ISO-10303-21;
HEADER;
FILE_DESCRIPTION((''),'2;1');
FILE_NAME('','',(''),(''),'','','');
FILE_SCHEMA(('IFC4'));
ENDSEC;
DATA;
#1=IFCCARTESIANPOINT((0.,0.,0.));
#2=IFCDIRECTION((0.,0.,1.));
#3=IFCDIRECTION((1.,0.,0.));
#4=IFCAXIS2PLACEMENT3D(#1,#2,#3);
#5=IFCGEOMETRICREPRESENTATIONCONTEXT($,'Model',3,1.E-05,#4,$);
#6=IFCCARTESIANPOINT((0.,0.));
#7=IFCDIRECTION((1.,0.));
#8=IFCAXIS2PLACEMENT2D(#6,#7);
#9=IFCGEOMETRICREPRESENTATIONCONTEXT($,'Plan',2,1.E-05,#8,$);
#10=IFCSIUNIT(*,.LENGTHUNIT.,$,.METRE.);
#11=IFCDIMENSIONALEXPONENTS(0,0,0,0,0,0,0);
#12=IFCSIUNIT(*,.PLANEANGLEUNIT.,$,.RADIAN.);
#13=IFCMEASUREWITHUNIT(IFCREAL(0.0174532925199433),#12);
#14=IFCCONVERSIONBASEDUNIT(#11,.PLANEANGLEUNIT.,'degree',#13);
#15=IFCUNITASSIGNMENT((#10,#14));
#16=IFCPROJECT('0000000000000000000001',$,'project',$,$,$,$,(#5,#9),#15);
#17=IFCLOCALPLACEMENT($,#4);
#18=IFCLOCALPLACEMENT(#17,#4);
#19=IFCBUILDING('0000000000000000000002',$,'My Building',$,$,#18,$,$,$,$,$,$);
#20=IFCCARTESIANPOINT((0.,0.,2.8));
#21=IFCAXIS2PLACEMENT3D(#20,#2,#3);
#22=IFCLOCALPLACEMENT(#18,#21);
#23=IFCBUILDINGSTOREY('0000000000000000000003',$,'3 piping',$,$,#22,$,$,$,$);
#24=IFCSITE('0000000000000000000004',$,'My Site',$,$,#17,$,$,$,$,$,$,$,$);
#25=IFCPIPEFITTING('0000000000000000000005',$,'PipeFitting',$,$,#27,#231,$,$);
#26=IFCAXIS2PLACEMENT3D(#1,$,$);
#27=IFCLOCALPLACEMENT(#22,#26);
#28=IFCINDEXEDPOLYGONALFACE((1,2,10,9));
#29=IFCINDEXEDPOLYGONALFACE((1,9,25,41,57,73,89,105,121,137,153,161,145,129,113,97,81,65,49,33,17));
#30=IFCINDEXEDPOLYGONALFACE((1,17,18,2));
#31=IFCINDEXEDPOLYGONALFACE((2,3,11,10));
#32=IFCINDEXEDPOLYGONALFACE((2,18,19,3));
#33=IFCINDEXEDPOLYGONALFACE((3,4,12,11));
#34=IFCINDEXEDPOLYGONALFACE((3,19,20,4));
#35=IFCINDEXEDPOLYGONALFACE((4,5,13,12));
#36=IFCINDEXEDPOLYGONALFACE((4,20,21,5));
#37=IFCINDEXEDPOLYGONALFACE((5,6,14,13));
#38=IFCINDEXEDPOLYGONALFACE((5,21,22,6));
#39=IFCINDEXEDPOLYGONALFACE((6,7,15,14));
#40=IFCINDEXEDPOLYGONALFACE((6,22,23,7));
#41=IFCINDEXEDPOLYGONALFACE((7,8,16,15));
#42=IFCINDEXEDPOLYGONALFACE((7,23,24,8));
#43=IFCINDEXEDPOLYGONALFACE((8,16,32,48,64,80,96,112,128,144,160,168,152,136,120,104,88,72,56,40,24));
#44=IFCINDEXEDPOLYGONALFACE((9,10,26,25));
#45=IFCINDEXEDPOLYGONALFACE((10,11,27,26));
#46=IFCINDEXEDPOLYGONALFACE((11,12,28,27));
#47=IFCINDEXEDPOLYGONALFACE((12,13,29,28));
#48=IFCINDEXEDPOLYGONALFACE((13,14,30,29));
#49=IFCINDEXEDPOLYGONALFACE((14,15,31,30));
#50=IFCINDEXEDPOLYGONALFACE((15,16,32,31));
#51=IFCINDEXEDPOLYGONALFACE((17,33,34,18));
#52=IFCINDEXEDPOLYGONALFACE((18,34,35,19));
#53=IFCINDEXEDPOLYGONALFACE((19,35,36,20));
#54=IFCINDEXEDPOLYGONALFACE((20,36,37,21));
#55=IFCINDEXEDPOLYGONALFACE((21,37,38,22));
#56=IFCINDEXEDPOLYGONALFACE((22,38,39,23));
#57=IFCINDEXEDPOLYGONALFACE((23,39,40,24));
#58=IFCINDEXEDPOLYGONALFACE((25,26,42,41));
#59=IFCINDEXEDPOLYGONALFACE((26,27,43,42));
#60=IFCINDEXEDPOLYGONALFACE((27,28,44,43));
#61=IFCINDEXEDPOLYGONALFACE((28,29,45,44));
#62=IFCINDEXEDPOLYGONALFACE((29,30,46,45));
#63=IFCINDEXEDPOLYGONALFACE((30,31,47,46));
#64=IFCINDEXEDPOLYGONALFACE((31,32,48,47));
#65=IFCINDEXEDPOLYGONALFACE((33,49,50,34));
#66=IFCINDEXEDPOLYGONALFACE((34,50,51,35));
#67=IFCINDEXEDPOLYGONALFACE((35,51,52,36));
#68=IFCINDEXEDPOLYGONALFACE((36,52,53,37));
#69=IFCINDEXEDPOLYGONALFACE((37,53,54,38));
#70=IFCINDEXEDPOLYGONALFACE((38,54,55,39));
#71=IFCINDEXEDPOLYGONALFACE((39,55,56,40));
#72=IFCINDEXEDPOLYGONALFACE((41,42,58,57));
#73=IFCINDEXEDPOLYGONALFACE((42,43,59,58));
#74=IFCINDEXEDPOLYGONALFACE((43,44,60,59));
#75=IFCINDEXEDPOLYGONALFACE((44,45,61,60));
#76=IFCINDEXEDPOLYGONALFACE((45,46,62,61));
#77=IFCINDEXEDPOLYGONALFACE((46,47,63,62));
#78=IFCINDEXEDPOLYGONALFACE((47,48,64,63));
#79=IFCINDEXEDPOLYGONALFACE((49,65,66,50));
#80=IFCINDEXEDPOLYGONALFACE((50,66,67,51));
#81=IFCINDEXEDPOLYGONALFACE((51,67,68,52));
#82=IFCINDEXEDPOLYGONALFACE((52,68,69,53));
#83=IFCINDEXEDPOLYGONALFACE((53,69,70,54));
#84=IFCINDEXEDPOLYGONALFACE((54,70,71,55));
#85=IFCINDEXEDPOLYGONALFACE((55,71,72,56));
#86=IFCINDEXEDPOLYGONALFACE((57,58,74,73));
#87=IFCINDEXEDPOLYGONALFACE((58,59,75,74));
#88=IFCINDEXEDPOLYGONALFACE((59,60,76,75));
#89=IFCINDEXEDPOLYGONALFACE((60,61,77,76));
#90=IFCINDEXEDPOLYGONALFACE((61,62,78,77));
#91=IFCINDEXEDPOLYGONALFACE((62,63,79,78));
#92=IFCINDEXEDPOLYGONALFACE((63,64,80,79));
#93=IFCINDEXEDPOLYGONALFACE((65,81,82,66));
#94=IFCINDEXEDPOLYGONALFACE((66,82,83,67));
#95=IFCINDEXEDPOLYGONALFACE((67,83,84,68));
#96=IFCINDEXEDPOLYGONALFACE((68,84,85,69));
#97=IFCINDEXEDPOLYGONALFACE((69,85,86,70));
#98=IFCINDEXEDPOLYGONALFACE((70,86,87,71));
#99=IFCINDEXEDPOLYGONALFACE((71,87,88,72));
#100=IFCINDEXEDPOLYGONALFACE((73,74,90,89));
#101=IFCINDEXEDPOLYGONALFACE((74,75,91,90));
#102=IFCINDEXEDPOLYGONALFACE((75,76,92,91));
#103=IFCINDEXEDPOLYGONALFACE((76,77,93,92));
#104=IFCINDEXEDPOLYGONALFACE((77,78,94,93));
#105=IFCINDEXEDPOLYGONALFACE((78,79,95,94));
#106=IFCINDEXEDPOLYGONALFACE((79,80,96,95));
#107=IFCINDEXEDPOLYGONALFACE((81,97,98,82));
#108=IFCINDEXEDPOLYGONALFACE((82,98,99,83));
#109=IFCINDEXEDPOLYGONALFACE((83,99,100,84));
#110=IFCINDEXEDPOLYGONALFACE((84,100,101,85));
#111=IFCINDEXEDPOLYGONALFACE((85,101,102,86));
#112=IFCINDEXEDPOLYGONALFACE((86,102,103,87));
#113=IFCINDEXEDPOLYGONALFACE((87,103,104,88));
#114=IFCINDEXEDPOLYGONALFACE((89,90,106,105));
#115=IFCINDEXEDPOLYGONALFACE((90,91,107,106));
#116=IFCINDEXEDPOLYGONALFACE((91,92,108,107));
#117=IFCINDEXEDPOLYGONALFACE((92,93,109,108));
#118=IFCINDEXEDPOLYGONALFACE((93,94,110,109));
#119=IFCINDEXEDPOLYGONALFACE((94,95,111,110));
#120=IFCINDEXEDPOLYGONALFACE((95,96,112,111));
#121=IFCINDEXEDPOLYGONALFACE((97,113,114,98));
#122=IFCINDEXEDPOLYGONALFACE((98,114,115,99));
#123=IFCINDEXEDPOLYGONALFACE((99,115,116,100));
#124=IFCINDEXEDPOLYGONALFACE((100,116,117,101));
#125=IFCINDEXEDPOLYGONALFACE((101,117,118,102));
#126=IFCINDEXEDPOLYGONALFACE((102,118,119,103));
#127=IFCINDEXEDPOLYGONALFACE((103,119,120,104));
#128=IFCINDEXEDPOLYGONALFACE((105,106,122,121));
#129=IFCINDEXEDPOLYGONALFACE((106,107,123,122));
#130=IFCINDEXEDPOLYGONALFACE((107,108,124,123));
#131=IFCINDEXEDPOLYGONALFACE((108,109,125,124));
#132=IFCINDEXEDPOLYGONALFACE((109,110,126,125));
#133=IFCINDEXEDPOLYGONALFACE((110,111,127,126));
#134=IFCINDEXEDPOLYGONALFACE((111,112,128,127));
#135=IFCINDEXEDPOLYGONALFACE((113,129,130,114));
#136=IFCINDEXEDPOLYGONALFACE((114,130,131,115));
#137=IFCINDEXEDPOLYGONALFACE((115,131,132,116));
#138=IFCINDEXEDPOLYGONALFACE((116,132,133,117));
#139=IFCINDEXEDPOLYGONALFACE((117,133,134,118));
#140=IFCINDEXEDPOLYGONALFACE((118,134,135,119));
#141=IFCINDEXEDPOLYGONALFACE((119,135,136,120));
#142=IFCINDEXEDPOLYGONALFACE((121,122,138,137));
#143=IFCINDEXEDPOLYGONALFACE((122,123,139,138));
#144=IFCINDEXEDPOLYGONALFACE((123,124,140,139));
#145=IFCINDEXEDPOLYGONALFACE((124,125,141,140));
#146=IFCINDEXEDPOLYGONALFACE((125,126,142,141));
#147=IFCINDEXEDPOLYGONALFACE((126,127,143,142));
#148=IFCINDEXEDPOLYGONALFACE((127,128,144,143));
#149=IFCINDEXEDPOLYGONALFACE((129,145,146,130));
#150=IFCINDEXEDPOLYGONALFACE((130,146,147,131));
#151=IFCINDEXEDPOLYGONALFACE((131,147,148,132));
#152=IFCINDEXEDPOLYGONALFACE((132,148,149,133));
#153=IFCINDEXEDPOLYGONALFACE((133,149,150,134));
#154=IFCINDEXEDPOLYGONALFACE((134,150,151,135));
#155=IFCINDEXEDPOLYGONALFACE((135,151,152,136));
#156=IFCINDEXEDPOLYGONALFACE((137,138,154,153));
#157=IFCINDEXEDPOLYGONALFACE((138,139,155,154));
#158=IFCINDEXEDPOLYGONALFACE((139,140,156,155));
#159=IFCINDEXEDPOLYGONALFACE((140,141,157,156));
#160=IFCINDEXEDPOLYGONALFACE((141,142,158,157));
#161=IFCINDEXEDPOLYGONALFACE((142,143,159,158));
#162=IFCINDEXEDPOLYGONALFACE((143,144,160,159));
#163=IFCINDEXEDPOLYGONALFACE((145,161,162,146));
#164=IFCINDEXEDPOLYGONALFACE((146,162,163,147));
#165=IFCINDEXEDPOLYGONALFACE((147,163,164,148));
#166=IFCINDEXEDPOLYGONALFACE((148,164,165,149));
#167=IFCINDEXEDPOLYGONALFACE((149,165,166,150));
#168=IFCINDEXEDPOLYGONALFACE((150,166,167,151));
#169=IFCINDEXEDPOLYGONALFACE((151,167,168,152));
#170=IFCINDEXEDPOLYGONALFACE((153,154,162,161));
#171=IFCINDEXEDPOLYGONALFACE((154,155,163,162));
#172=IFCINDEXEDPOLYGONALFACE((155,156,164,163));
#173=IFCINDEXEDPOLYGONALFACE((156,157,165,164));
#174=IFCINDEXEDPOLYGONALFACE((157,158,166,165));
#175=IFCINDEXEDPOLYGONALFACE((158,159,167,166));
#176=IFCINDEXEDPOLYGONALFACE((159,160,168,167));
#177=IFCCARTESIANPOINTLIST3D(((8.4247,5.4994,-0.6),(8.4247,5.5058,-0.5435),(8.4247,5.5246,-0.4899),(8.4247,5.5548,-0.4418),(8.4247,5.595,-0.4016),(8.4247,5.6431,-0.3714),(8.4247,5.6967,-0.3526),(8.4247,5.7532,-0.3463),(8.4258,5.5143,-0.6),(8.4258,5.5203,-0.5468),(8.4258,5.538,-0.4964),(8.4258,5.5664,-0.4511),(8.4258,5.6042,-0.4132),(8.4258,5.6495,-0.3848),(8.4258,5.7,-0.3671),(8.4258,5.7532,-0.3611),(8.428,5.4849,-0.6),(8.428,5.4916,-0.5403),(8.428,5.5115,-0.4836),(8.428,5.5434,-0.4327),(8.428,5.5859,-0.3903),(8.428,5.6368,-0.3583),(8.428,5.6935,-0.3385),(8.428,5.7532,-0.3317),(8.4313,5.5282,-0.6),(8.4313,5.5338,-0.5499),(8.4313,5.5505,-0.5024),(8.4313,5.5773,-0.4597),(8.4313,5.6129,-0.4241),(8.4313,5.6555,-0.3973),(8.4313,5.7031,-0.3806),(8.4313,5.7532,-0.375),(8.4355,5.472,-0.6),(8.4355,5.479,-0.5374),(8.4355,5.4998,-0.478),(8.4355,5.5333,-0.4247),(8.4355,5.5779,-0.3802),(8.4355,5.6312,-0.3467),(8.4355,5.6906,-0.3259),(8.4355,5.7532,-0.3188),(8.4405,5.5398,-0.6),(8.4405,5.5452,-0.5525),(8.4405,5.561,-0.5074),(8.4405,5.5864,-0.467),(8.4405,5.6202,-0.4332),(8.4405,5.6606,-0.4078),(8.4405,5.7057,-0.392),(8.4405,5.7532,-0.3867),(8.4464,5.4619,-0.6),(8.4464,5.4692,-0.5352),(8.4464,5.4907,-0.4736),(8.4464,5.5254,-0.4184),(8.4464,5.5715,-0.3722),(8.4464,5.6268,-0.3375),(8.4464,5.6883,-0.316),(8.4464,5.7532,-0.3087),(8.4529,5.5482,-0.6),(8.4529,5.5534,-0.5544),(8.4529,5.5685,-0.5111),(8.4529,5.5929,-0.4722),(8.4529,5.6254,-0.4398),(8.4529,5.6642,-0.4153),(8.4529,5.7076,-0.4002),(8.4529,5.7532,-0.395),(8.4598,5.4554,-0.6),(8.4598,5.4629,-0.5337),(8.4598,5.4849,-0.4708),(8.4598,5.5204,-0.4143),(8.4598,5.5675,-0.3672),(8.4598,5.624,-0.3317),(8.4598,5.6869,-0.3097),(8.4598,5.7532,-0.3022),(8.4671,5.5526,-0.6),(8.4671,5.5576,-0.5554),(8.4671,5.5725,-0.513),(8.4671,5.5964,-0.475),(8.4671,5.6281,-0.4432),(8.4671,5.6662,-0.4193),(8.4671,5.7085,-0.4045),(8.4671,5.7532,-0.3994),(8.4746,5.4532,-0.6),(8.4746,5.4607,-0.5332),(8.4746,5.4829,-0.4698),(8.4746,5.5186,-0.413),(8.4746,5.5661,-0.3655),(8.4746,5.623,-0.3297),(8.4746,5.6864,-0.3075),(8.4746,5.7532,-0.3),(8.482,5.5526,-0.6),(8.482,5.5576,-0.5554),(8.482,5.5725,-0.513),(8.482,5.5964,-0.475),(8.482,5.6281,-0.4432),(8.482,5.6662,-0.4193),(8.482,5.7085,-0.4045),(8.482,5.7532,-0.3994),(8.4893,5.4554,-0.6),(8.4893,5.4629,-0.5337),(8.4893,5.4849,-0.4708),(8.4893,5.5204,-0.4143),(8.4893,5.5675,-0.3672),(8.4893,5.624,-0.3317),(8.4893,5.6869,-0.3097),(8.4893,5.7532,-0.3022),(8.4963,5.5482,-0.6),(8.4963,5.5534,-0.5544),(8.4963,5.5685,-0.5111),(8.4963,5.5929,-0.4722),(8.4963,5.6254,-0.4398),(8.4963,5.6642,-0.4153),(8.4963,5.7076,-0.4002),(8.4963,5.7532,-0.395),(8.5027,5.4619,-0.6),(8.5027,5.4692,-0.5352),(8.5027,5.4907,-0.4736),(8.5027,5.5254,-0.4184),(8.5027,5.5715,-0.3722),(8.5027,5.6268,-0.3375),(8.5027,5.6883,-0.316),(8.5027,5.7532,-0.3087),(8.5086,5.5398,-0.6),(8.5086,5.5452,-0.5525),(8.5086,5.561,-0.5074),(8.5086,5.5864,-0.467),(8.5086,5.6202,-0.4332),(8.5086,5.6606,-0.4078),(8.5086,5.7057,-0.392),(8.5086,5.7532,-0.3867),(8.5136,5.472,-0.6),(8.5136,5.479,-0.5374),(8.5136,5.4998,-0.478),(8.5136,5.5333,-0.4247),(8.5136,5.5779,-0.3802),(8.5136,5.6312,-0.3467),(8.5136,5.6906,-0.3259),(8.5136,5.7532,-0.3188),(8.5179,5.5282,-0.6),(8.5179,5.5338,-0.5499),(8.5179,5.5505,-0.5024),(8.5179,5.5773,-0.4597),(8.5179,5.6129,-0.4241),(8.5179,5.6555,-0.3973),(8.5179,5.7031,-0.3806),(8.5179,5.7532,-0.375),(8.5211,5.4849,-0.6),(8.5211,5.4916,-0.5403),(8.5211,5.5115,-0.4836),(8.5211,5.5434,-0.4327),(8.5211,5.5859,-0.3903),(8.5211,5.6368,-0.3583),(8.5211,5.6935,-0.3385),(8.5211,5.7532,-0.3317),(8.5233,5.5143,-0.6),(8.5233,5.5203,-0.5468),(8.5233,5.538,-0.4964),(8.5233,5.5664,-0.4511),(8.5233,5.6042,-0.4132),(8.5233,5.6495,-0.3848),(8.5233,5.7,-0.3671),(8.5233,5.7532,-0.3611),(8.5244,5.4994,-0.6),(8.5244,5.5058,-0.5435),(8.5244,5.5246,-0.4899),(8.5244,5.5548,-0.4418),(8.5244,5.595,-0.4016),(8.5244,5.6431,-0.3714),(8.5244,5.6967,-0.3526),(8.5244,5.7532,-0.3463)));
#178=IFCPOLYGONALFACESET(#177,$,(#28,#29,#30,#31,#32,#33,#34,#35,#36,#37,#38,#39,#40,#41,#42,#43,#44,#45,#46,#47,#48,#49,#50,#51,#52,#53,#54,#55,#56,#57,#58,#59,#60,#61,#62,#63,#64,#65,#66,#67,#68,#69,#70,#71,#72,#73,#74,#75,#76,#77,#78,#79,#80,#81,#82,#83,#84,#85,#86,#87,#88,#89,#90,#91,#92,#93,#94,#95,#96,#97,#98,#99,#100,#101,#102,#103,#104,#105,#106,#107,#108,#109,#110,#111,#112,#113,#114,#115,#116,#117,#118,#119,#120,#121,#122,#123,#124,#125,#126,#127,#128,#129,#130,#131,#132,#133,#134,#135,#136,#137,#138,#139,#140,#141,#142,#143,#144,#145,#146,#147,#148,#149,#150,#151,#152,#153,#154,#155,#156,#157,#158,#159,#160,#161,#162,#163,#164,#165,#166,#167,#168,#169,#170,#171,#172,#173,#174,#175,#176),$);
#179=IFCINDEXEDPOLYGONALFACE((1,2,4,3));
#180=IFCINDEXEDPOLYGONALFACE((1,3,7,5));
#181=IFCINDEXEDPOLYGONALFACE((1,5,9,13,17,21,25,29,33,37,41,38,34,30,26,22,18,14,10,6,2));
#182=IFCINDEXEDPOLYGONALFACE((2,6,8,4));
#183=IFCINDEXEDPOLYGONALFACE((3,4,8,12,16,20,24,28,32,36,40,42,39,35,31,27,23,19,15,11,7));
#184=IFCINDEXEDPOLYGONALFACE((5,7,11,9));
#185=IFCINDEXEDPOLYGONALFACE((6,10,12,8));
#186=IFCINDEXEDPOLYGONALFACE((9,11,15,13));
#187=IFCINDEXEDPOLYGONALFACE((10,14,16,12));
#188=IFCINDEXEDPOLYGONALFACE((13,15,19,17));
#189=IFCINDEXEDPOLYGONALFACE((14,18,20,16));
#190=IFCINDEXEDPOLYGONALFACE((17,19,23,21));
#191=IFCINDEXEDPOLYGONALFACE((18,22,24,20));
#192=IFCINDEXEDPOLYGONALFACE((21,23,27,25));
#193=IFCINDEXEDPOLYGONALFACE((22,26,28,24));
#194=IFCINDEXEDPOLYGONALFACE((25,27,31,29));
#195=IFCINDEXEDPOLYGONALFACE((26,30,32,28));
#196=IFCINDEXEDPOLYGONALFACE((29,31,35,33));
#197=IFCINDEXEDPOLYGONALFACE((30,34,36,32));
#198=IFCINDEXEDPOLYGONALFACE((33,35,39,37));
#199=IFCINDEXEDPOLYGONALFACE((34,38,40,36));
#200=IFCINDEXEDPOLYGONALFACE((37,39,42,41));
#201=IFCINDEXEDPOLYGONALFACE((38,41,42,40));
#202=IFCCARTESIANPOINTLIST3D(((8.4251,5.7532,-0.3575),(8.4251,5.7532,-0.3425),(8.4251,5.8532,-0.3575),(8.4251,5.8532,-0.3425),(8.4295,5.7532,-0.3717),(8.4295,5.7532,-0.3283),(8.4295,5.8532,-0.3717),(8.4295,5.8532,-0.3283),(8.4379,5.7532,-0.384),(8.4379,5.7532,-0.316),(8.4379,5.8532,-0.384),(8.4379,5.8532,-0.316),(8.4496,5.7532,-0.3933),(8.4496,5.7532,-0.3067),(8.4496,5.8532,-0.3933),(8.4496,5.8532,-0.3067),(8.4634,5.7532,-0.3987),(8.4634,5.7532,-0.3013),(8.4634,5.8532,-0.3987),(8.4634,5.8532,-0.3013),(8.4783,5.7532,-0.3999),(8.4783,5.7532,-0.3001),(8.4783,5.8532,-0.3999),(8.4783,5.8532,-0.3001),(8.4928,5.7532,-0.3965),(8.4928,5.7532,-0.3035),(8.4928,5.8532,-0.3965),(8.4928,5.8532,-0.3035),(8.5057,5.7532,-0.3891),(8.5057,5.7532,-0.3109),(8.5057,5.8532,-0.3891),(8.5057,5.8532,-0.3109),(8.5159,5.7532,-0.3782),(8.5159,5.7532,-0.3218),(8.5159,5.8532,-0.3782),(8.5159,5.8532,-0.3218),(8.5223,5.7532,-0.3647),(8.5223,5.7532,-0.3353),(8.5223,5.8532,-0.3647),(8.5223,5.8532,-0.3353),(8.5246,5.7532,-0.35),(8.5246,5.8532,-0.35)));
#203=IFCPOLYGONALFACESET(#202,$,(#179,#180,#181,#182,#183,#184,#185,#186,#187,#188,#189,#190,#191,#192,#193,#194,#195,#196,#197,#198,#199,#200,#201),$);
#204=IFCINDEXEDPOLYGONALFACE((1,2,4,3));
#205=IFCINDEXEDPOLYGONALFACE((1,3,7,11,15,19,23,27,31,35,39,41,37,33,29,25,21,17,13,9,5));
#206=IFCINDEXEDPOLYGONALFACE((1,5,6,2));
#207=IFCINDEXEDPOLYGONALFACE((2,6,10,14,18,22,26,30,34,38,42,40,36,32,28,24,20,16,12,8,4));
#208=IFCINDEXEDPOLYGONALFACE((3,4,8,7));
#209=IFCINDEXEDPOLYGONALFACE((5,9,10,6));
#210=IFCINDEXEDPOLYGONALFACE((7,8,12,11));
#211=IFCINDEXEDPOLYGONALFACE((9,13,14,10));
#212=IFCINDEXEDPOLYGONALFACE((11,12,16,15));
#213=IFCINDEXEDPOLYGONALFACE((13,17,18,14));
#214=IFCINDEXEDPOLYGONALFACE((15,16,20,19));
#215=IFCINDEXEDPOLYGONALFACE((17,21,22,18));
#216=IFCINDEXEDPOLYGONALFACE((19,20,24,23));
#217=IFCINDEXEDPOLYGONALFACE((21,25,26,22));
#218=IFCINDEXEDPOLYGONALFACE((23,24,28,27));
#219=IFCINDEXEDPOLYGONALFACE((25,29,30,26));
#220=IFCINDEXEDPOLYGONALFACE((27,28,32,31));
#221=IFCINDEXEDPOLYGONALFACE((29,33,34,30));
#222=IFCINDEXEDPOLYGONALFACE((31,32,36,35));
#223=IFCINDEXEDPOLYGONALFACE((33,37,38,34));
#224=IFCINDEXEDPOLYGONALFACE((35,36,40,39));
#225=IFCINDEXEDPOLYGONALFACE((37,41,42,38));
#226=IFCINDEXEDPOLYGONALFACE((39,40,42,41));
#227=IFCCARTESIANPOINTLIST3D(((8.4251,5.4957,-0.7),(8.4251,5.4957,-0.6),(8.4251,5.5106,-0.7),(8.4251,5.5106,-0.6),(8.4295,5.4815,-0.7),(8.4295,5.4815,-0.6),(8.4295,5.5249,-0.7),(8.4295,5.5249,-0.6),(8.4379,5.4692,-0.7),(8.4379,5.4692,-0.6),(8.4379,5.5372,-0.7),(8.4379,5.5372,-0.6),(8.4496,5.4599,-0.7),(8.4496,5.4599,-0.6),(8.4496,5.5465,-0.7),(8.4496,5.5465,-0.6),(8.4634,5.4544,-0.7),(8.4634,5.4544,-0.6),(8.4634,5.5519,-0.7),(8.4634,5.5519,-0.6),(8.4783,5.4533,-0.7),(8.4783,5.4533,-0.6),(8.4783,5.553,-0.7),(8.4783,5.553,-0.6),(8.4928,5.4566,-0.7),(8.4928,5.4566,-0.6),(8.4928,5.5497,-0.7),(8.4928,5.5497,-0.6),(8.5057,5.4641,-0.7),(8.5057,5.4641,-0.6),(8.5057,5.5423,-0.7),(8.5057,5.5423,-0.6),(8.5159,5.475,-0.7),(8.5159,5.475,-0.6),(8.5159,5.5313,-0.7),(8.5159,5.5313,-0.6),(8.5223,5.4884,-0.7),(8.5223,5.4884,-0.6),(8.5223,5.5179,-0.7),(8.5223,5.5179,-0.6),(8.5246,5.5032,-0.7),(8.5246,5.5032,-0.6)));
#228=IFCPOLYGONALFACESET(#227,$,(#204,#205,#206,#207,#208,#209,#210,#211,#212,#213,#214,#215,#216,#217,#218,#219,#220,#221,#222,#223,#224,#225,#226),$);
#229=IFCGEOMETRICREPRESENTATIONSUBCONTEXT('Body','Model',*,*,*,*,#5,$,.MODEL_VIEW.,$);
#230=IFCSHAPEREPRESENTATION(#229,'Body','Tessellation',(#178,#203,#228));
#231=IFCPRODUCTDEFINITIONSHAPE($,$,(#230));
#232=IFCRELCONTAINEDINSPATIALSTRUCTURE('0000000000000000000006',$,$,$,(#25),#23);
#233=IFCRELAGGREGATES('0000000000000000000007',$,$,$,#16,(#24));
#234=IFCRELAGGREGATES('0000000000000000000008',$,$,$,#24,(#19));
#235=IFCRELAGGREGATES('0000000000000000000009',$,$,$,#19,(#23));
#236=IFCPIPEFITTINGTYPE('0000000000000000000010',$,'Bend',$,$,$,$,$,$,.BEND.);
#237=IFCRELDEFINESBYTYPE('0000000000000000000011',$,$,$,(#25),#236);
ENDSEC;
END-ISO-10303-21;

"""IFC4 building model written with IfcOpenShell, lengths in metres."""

from ifc_helpers import new_model, entity, si_unit, converted_unit, frame, origin_with_axes, origin_2d_with_axis, place, context, subcontext, project, spatial, circle, extrude, source, transform, mapped, type_object, type_shapes, element, save


model = new_model("IFC4")

# Units and contexts
model_context = context("Model", 3, precision=1e-05, world=origin_with_axes())
plan_context = context("Plan", 2, precision=1e-05, world=origin_2d_with_axis())
body_context = subcontext(model_context, "Body", "Model", "MODEL_VIEW")
ifc_project = project(units=[si_unit("LENGTHUNIT", "METRE"), converted_unit("PLANEANGLEUNIT", "degree", entity("IfcReal", 0.0174532925199433), si_unit("PLANEANGLEUNIT", "RADIAN"), dimensions=[0, 0, 0, 0, 0, 0, 0])], contexts=[model_context, plan_context])

# Site, building, storey
site_placement = place(None, origin_with_axes())
site = spatial("IfcSite", under=ifc_project, at=site_placement, Name="My Site")
building_placement = place(site_placement, origin_with_axes())
building = spatial("IfcBuilding", under=site, at=building_placement, Name="My Building")
storey_placement = place(building_placement, frame((0.0, 0.0, 2.8), z_axis=(0.0, 0.0, 1.0), x_axis=(1.0, 0.0, 0.0)))
storey = spatial("IfcBuildingStorey", under=building, at=storey_placement, Name="3 piping")

# Pipe fitting
pipe_fitting_type_1 = type_object("IfcPipeFittingType", Name="Bend", PredefinedType="BEND")
shared_shape = source(origin_with_axes(), body_context, "Body", "SolidModel", [
    entity("IfcSweptDiskSolid", entity("IfcIndexedPolyCurve", entity("IfcCartesianPointList3D", [[0.0, 0.0, 0.1], [0.0, -0.0732, 0.2768], [0.0, -0.25, 0.35]]), [entity("IfcArcIndex", [1, 2, 3])]), 0.05),
    extrude(circle(Radius=0.05), origin_with_axes(), (0.0, 0.0, 1.0), 0.1),
    extrude(circle(Radius=0.05), frame((0.0, -0.25, 0.35), z_axis=(0.0, -1.0, 0.0), x_axis=(1.0, 0.0, 0.0)), (0.0, 0.0, 1.0), 0.1),
])
type_shapes(pipe_fitting_type_1, [shared_shape])
for number, where, z_axis, x_axis, name in (
    (1, (8.4746, 5.8532, -0.35), (0.0, -1.0, 0.0), (1.0, 0.0, 0.0), "PipeFitting"),
):
    element("IfcPipeFitting", number, at=place(storey_placement, frame(where, z_axis=z_axis, x_axis=x_axis)), inside=storey, type_object=pipe_fitting_type_1, Name=name, context=body_context, shape_type="MappedRepresentation", body=[
        mapped(shared_shape, transform((0.0, 0.0, 0.0), x_axis=(1.0, 0.0, 0.0), y_axis=(0.0, 1.0, 0.0), z_axis=(0.0, 0.0, 1.0), scale=1.0)),
    ])

save(model, "model.ifc")
